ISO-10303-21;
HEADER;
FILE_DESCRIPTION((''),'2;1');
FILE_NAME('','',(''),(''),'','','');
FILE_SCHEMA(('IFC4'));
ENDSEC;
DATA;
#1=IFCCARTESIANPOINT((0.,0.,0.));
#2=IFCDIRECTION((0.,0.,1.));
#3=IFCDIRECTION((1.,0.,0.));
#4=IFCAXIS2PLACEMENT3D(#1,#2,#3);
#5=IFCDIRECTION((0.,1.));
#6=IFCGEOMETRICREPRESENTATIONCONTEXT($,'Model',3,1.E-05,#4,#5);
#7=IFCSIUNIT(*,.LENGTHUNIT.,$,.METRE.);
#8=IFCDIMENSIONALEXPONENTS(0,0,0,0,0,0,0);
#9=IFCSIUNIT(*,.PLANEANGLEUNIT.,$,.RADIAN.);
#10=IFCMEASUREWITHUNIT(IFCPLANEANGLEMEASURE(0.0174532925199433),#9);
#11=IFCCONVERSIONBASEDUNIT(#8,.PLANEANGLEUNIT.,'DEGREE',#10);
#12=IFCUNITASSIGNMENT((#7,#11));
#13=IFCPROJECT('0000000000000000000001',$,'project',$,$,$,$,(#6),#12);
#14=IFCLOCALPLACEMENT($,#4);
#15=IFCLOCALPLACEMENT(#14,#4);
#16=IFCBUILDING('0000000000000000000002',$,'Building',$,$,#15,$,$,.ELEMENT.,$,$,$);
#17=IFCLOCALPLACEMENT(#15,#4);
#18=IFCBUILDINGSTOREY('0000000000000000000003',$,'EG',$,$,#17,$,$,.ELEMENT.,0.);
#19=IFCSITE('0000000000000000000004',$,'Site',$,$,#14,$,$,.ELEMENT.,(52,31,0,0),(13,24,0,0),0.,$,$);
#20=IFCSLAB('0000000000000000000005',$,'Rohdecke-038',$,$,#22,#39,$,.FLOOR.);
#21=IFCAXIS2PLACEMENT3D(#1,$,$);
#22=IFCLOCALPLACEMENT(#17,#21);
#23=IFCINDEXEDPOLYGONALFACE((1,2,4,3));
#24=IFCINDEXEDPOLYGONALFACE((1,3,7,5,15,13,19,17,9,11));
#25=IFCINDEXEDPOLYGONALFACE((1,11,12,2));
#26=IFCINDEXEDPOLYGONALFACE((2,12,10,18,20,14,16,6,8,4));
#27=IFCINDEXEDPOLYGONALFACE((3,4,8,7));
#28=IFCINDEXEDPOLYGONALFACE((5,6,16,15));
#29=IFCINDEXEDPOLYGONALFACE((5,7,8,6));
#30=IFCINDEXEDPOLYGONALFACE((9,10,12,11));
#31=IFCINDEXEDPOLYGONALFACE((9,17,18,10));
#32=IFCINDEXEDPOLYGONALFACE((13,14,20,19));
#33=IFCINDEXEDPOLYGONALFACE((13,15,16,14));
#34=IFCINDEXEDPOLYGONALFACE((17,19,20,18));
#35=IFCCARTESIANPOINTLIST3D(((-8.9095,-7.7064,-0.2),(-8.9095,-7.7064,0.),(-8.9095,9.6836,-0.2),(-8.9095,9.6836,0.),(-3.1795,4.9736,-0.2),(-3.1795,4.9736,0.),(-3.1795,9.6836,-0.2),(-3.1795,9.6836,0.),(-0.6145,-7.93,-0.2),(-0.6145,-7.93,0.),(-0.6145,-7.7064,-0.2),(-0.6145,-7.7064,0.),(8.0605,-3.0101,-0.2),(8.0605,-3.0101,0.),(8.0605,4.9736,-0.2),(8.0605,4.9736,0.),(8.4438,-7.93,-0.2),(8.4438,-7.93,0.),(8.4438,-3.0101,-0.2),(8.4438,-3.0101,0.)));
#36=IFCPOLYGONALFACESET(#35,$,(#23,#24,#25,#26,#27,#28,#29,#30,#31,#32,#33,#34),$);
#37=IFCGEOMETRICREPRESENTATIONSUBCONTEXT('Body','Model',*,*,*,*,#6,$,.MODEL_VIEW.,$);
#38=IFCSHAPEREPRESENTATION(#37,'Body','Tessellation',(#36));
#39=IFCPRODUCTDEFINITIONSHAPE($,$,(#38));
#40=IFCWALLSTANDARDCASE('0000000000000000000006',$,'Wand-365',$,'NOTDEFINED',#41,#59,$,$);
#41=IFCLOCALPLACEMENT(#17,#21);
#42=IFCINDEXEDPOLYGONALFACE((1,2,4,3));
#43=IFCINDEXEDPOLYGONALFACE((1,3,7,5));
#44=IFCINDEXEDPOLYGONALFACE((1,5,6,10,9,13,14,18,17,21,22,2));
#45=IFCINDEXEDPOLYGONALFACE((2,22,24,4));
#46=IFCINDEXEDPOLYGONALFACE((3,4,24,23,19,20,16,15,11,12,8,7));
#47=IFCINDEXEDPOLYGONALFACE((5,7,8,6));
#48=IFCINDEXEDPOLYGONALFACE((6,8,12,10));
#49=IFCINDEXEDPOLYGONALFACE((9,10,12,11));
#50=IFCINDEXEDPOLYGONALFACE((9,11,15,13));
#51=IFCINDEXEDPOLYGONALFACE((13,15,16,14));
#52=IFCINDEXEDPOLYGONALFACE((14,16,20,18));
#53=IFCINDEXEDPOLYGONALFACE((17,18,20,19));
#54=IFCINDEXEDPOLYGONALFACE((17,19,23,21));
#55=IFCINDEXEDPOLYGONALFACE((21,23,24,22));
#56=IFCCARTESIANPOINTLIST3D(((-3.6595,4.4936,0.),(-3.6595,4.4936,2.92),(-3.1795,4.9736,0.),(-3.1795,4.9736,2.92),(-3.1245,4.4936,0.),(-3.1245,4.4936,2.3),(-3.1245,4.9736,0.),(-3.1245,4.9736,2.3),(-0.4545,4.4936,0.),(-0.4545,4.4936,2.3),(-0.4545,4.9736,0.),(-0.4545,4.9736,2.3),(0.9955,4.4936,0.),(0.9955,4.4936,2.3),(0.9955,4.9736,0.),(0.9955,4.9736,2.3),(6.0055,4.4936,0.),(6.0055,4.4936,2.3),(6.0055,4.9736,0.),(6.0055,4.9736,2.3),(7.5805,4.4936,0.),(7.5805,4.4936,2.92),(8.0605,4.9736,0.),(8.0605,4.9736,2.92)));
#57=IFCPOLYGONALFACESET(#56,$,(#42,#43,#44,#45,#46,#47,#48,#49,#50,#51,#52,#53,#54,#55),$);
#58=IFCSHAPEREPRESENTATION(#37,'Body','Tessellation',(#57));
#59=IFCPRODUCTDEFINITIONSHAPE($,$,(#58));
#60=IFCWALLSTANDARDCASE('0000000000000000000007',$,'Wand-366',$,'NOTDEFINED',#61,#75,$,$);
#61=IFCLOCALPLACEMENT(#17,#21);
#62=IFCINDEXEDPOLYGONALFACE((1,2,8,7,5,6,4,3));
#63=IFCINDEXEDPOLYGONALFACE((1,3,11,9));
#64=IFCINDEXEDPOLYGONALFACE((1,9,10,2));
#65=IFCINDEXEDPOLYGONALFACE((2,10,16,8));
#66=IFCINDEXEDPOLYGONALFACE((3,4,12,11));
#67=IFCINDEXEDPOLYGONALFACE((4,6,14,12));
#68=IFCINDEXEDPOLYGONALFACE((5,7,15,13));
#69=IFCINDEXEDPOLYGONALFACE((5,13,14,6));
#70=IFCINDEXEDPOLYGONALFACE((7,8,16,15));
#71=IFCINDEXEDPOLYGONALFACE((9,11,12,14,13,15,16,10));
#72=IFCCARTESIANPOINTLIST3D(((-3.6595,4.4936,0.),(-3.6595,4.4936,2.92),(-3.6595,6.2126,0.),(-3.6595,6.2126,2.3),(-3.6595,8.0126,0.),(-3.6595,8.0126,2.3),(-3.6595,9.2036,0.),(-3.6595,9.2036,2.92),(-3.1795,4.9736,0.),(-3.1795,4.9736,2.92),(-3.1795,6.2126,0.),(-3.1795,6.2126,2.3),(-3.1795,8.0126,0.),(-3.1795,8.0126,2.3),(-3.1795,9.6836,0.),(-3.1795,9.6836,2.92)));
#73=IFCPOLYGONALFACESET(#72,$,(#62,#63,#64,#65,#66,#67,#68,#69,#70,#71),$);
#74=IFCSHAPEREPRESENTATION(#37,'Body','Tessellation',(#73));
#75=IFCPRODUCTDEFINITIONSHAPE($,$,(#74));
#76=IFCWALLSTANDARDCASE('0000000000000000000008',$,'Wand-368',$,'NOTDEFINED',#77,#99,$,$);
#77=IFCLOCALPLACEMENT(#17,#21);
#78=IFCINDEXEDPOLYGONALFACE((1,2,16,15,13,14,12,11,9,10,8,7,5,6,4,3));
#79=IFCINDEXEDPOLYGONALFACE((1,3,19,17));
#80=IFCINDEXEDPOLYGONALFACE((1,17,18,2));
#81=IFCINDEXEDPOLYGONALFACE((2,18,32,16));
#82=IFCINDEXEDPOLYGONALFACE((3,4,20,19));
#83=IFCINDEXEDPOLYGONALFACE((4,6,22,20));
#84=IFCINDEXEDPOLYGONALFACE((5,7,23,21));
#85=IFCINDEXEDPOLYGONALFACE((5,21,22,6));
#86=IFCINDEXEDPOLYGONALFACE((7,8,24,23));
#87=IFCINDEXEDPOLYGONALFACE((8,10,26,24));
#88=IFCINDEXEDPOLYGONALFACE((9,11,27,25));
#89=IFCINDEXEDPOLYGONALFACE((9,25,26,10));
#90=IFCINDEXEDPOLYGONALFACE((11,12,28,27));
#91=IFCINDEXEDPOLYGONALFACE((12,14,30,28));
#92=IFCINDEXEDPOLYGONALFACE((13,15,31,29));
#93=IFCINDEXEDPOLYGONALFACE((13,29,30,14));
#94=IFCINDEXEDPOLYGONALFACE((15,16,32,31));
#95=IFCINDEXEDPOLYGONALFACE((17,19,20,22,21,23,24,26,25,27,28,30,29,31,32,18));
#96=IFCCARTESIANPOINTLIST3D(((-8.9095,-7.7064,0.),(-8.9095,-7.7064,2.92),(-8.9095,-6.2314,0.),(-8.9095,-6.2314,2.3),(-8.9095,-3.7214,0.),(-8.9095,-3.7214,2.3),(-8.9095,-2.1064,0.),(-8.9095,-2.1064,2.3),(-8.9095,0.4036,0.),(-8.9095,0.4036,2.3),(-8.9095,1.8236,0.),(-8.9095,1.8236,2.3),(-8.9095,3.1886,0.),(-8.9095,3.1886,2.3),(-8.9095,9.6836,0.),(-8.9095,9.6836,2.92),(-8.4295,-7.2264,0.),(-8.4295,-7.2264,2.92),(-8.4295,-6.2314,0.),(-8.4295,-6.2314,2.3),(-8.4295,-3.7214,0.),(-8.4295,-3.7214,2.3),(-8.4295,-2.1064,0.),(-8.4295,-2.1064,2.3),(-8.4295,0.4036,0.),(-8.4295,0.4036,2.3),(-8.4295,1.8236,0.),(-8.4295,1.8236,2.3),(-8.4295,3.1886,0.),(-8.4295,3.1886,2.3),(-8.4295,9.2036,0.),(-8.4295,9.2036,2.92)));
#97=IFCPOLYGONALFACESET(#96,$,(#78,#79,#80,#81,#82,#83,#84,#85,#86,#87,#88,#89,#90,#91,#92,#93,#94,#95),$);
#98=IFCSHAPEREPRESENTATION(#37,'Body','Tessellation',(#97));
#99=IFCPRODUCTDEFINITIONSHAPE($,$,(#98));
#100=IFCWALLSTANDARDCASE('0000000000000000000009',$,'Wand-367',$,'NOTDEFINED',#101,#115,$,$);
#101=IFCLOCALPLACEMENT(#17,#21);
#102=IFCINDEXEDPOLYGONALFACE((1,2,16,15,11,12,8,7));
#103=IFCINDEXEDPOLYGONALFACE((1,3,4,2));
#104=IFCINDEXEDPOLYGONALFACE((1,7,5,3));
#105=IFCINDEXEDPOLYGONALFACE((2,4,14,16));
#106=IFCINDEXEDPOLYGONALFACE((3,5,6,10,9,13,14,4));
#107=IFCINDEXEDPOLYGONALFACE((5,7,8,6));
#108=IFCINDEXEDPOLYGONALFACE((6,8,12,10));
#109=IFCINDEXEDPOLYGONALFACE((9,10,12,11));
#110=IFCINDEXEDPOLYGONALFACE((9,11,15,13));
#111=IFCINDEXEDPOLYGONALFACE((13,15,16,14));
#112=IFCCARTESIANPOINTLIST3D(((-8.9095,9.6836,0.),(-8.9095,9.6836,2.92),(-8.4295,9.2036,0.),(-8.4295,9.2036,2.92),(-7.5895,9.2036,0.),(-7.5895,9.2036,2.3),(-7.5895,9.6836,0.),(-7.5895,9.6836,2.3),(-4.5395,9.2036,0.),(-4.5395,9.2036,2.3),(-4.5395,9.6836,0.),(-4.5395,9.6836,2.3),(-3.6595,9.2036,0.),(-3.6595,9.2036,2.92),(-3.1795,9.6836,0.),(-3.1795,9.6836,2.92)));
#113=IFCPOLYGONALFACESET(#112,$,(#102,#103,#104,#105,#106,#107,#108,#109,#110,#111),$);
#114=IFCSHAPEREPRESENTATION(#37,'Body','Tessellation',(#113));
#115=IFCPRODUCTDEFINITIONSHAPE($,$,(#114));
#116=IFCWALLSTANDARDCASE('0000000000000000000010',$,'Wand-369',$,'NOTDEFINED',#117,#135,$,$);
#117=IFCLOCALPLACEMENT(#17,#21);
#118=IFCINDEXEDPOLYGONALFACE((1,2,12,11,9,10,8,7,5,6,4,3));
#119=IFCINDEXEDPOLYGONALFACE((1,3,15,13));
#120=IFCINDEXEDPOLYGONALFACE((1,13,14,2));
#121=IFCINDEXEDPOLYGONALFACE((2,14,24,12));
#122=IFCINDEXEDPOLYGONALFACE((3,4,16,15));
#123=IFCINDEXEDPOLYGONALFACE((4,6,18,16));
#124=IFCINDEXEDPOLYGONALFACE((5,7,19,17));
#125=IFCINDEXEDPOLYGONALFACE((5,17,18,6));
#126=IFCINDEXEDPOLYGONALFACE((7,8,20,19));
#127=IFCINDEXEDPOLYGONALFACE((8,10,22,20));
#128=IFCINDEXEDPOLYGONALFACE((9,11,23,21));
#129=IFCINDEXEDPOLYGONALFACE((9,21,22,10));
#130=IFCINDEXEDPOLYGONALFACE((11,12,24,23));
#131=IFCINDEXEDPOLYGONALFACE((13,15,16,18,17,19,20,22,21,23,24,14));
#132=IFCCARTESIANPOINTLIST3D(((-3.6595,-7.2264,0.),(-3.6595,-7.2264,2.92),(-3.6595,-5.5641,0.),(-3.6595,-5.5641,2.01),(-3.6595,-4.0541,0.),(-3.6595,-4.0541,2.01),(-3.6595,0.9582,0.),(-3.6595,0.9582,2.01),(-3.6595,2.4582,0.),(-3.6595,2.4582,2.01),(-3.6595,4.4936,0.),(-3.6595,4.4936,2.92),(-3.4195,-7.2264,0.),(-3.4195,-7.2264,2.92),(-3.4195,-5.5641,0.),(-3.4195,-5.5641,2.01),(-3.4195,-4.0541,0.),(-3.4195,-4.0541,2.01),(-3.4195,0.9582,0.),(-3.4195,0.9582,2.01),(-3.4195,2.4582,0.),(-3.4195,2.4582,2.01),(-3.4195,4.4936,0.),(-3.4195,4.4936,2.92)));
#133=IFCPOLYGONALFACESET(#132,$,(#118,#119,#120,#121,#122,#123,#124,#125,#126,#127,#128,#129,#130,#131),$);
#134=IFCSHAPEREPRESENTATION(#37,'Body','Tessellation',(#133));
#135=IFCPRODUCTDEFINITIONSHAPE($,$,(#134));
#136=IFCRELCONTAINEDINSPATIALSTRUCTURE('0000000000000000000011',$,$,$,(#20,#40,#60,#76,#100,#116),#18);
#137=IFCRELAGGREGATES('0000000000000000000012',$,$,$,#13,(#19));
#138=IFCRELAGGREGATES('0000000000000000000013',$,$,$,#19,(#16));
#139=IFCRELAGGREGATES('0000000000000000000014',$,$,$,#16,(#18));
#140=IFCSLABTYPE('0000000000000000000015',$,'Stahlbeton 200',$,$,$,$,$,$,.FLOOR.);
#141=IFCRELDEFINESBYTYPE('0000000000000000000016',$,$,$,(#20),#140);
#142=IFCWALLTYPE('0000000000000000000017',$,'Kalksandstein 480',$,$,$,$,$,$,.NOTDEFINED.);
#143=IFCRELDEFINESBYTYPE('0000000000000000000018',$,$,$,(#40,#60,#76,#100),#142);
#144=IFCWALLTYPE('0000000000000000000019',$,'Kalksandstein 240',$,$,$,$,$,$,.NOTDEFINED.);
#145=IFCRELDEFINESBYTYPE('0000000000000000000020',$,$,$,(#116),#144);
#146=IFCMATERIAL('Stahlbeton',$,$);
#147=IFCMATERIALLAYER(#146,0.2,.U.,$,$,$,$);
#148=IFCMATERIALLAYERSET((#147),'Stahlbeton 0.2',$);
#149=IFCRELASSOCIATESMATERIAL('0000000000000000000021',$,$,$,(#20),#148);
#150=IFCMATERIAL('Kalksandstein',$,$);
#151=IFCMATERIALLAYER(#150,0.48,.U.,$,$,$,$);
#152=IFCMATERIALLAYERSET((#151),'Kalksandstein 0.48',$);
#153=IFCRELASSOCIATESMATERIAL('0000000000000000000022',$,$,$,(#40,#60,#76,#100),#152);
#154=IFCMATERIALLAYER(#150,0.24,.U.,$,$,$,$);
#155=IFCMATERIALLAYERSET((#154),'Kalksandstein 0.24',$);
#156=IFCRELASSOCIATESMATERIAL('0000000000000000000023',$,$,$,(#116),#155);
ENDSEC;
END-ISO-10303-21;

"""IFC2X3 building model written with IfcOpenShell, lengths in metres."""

from ifc_helpers import new_model, entity, si_unit, converted_unit, direction, frame, origin_with_axes, origin_2d_with_axis, place, context, subcontext, project, spatial, polyline, rectangle, outline, extrude, material, layer, layer_set, layer_usage, type_object, element, save


model = new_model("IFC2X3")

# Units and contexts
model_context = context("Model", 3, precision=1e-05, world=origin_with_axes(), true_north=direction((0.0, 1.0)))
body_context = subcontext(model_context, "Body", "Model", "MODEL_VIEW")
ifc_project = project(units=[si_unit("LENGTHUNIT", "METRE"), converted_unit("PLANEANGLEUNIT", "DEGREE", entity("IfcPlaneAngleMeasure", 0.0174532925199433), si_unit("PLANEANGLEUNIT", "RADIAN"), dimensions=[0, 0, 0, 0, 0, 0, 0])], contexts=[model_context])

# Site, building, storey
site_placement = place(None, origin_with_axes())
site = spatial("IfcSite", under=ifc_project, at=site_placement, Name="Site", CompositionType="ELEMENT", RefLatitude=(52, 31, 0, 0), RefLongitude=(13, 24, 0, 0), RefElevation=0.0)
building_placement = place(site_placement, origin_with_axes())
building = spatial("IfcBuilding", under=site, at=building_placement, Name="Building", CompositionType="ELEMENT")
storey_placement = place(building_placement, origin_with_axes())
storey = spatial("IfcBuildingStorey", under=building, at=storey_placement, Name="EG", CompositionType="ELEMENT", Elevation=0.0)

# Slab
ifc_material_1 = material(Name="Stahlbeton")
ifc_layer_1 = layer(ifc_material_1, 0.2, ventilated="UNKNOWN")
ifc_layer_set_1 = layer_set([ifc_layer_1], Name="Stahlbeton 0.2")
ifc_layer_usage_1 = layer_usage(ifc_layer_set_1, "AXIS3", "NEGATIVE", 0.2)
slab_type = type_object("IfcSlabType", Name="Stahlbeton 200", PredefinedType="FLOOR")
slab_placement = place(storey_placement, frame((-3.1795, 9.6836, 0.0), z_axis=(0.0, 0.0, 1.0), x_axis=(1.0, 0.0, 0.0)))
element("IfcSlab", 1, at=slab_placement, inside=storey, type_object=slab_type, material=ifc_layer_usage_1, Name="Rohdecke-038", PredefinedType="FLOOR", context=body_context, shape_type="SweptSolid", body=[
    extrude(outline(polyline([(0.0, 0.0), (-5.73, 0.0), (-5.73, -17.39), (2.565, -17.39), (2.565, -17.6137), (11.6233, -17.6137), (11.6233, -12.6938), (11.24, -12.6938), (11.24, -4.71), (0.0, -4.71), (0.0, 0.0)])), frame((0.0, 0.0, -0.2), z_axis=(0.0, 0.0, 1.0), x_axis=(1.0, 0.0, 0.0)), (0.0, 0.0, 1.0), 0.2),
])

# Wall, openings
ifc_material_2 = material(Name="Kalksandstein")
ifc_layer_2 = layer(ifc_material_2, 0.48, ventilated="UNKNOWN")
ifc_layer_set_2 = layer_set([ifc_layer_2], Name="Kalksandstein 0.48")
ifc_layer_usage_2 = layer_usage(ifc_layer_set_2, "AXIS2", "POSITIVE", 0.0)
wall_type_1 = type_object("IfcWallType", Name="Kalksandstein 480", PredefinedType="NOTDEFINED")
wall_1_placement = place(storey_placement, frame((8.0605, 4.9736, 0.0), z_axis=(0.0, 0.0, 1.0), x_axis=(-1.0, 0.0, 0.0)))
wall_1 = element("IfcWallStandardCase", 2, at=wall_1_placement, inside=storey, type_object=wall_type_1, material=ifc_layer_usage_2, Name="Wand-365", ObjectType="NOTDEFINED", context=body_context, shape_type="SweptSolid", body=[
    extrude(outline(polyline([(0.0, 0.0), (11.24, 0.0), (11.72, 0.48), (0.48, 0.48), (0.0, 0.0)])), origin_with_axes(), (0.0, 0.0, 1.0), 2.92),
])
opening_1_placement = place(wall_1_placement, frame((4.56, 0.0, 0.0), z_axis=(0.0, 0.0, 1.0), x_axis=(1.0, 0.0, 0.0)))
element("IfcOpeningElement", 3, at=opening_1_placement, cuts=wall_1, context=body_context, shape_type="SweptSolid", body=[
    extrude(rectangle(XDim=5.01, YDim=2.3, at=origin_2d_with_axis()), frame((0.0, 0.48, 1.15), z_axis=(0.0, -1.0, 0.0), x_axis=(-1.0, 0.0, 0.0)), (0.0, 0.0, 1.0), 1.44),
])
opening_2_placement = place(wall_1_placement, frame((9.85, 0.0, 0.0), z_axis=(0.0, 0.0, 1.0), x_axis=(1.0, 0.0, 0.0)))
element("IfcOpeningElement", 4, at=opening_2_placement, cuts=wall_1, context=body_context, shape_type="SweptSolid", body=[
    extrude(rectangle(XDim=2.67, YDim=2.3, at=origin_2d_with_axis()), frame((0.0, 0.48, 1.15), z_axis=(0.0, -1.0, 0.0), x_axis=(-1.0, 0.0, 0.0)), (0.0, 0.0, 1.0), 1.44),
])

# Wall, opening
ifc_layer_usage_3 = layer_usage(ifc_layer_set_2, "AXIS2", "POSITIVE", 0.0)
wall_2_placement = place(storey_placement, frame((-3.1795, 4.9736, 0.0), z_axis=(0.0, 0.0, 1.0), x_axis=(0.0, 1.0, 0.0)))
wall_2 = element("IfcWallStandardCase", 5, at=wall_2_placement, inside=storey, type_object=wall_type_1, material=ifc_layer_usage_3, Name="Wand-366", ObjectType="NOTDEFINED", context=body_context, shape_type="SweptSolid", body=[
    extrude(outline(polyline([(0.0, 0.0), (4.71, 0.0), (4.23, 0.48), (-0.48, 0.48), (0.0, 0.0)])), origin_with_axes(), (0.0, 0.0, 1.0), 2.92),
])
opening_3_placement = place(wall_2_placement, frame((2.139, 0.0, 0.0), z_axis=(0.0, 0.0, 1.0), x_axis=(1.0, 0.0, 0.0)))
element("IfcOpeningElement", 6, at=opening_3_placement, cuts=wall_2, context=body_context, shape_type="SweptSolid", body=[
    extrude(rectangle(XDim=1.8, YDim=2.3, at=origin_2d_with_axis()), frame((0.0, 0.48, 1.15), z_axis=(0.0, -1.0, 0.0), x_axis=(-1.0, 0.0, 0.0)), (0.0, 0.0, 1.0), 1.44),
])

# Wall, openings
ifc_layer_usage_4 = layer_usage(ifc_layer_set_2, "AXIS2", "POSITIVE", 0.0)
wall_3_placement = place(storey_placement, frame((-8.9095, 9.6836, 0.0), z_axis=(0.0, 0.0, 1.0), x_axis=(0.0, -1.0, 0.0)))
wall_3 = element("IfcWallStandardCase", 7, at=wall_3_placement, inside=storey, type_object=wall_type_1, material=ifc_layer_usage_4, Name="Wand-368", ObjectType="NOTDEFINED", context=body_context, shape_type="SweptSolid", body=[
    extrude(outline(polyline([(0.0, 0.0), (17.39, 0.0), (16.91, 0.48), (0.48, 0.48), (0.0, 0.0)])), origin_with_axes(), (0.0, 0.0, 1.0), 2.92),
])
opening_4_placement = place(wall_3_placement, frame((7.1775, 0.0, 0.0), z_axis=(0.0, 0.0, 1.0), x_axis=(1.0, 0.0, 0.0)))
element("IfcOpeningElement", 8, at=opening_4_placement, cuts=wall_3, context=body_context, shape_type="SweptSolid", body=[
    extrude(rectangle(XDim=1.365, YDim=2.3, at=origin_2d_with_axis()), frame((0.0, 0.48, 1.15), z_axis=(0.0, -1.0, 0.0), x_axis=(-1.0, 0.0, 0.0)), (0.0, 0.0, 1.0), 1.44),
])
opening_5_placement = place(wall_3_placement, frame((10.535, 0.0, 0.0), z_axis=(0.0, 0.0, 1.0), x_axis=(1.0, 0.0, 0.0)))
element("IfcOpeningElement", 9, at=opening_5_placement, cuts=wall_3, context=body_context, shape_type="SweptSolid", body=[
    extrude(rectangle(XDim=2.51, YDim=2.3, at=origin_2d_with_axis()), frame((0.0, 0.48, 1.15), z_axis=(0.0, -1.0, 0.0), x_axis=(-1.0, 0.0, 0.0)), (0.0, 0.0, 1.0), 1.44),
])
opening_6_placement = place(wall_3_placement, frame((14.66, 0.0, 0.0), z_axis=(0.0, 0.0, 1.0), x_axis=(1.0, 0.0, 0.0)))
element("IfcOpeningElement", 10, at=opening_6_placement, cuts=wall_3, context=body_context, shape_type="SweptSolid", body=[
    extrude(rectangle(XDim=2.51, YDim=2.3, at=origin_2d_with_axis()), frame((0.0, 0.48, 1.15), z_axis=(0.0, -1.0, 0.0), x_axis=(-1.0, 0.0, 0.0)), (0.0, 0.0, 1.0), 1.44),
])

# Wall, opening
ifc_layer_usage_5 = layer_usage(ifc_layer_set_2, "AXIS2", "POSITIVE", 0.0)
wall_4_placement = place(storey_placement, frame((-3.1795, 9.6836, 0.0), z_axis=(0.0, 0.0, 1.0), x_axis=(-1.0, 0.0, 0.0)))
wall_4 = element("IfcWallStandardCase", 11, at=wall_4_placement, inside=storey, type_object=wall_type_1, material=ifc_layer_usage_5, Name="Wand-367", ObjectType="NOTDEFINED", context=body_context, shape_type="SweptSolid", body=[
    extrude(outline(polyline([(0.0, 0.0), (5.73, 0.0), (5.25, 0.48), (0.48, 0.48), (0.0, 0.0)])), origin_with_axes(), (0.0, 0.0, 1.0), 2.92),
])
opening_7_placement = place(wall_4_placement, frame((2.885, 0.0, 0.0), z_axis=(0.0, 0.0, 1.0), x_axis=(1.0, 0.0, 0.0)))
element("IfcOpeningElement", 12, at=opening_7_placement, cuts=wall_4, context=body_context, shape_type="SweptSolid", body=[
    extrude(rectangle(XDim=3.05, YDim=2.3, at=origin_2d_with_axis()), frame((0.0, 0.48, 1.15), z_axis=(0.0, -1.0, 0.0), x_axis=(-1.0, 0.0, 0.0)), (0.0, 0.0, 1.0), 1.44),
])

# Wall, openings
ifc_layer_3 = layer(ifc_material_2, 0.24, ventilated="UNKNOWN")
ifc_layer_set_3 = layer_set([ifc_layer_3], Name="Kalksandstein 0.24")
ifc_layer_usage_6 = layer_usage(ifc_layer_set_3, "AXIS2", "POSITIVE", 0.0)
wall_type_2 = type_object("IfcWallType", Name="Kalksandstein 240", PredefinedType="NOTDEFINED")
wall_5_placement = place(storey_placement, frame((-3.6595, 4.4936, 0.0), z_axis=(0.0, 0.0, 1.0), x_axis=(0.0, -1.0, 0.0)))
wall_5 = element("IfcWallStandardCase", 13, at=wall_5_placement, inside=storey, type_object=wall_type_2, material=ifc_layer_usage_6, Name="Wand-369", ObjectType="NOTDEFINED", context=body_context, shape_type="SweptSolid", body=[
    extrude(outline(polyline([(0.0, 0.0), (11.72, 0.0), (11.72, 0.24), (0.0, 0.24), (0.0, 0.0)])), origin_with_axes(), (0.0, 0.0, 1.0), 2.92),
])
opening_8_placement = place(wall_5_placement, frame((9.3028, 0.0, 0.0), z_axis=(0.0, 0.0, 1.0), x_axis=(1.0, 0.0, 0.0)))
element("IfcOpeningElement", 14, at=opening_8_placement, cuts=wall_5, context=body_context, shape_type="SweptSolid", body=[
    extrude(rectangle(XDim=1.51, YDim=2.01, at=origin_2d_with_axis()), frame((0.0, -0.24, 1.005), z_axis=(0.0, 1.0, 0.0), x_axis=(1.0, 0.0, 0.0)), (0.0, 0.0, 1.0), 0.72),
])
opening_9_placement = place(wall_5_placement, frame((2.7855, 0.0, 0.0), z_axis=(0.0, 0.0, 1.0), x_axis=(1.0, 0.0, 0.0)))
element("IfcOpeningElement", 15, at=opening_9_placement, cuts=wall_5, context=body_context, shape_type="SweptSolid", body=[
    extrude(rectangle(XDim=1.5, YDim=2.01, at=origin_2d_with_axis()), frame((0.0, -0.24, 1.005), z_axis=(0.0, 1.0, 0.0), x_axis=(1.0, 0.0, 0.0)), (0.0, 0.0, 1.0), 0.72),
])

save(model, "model.ifc")
